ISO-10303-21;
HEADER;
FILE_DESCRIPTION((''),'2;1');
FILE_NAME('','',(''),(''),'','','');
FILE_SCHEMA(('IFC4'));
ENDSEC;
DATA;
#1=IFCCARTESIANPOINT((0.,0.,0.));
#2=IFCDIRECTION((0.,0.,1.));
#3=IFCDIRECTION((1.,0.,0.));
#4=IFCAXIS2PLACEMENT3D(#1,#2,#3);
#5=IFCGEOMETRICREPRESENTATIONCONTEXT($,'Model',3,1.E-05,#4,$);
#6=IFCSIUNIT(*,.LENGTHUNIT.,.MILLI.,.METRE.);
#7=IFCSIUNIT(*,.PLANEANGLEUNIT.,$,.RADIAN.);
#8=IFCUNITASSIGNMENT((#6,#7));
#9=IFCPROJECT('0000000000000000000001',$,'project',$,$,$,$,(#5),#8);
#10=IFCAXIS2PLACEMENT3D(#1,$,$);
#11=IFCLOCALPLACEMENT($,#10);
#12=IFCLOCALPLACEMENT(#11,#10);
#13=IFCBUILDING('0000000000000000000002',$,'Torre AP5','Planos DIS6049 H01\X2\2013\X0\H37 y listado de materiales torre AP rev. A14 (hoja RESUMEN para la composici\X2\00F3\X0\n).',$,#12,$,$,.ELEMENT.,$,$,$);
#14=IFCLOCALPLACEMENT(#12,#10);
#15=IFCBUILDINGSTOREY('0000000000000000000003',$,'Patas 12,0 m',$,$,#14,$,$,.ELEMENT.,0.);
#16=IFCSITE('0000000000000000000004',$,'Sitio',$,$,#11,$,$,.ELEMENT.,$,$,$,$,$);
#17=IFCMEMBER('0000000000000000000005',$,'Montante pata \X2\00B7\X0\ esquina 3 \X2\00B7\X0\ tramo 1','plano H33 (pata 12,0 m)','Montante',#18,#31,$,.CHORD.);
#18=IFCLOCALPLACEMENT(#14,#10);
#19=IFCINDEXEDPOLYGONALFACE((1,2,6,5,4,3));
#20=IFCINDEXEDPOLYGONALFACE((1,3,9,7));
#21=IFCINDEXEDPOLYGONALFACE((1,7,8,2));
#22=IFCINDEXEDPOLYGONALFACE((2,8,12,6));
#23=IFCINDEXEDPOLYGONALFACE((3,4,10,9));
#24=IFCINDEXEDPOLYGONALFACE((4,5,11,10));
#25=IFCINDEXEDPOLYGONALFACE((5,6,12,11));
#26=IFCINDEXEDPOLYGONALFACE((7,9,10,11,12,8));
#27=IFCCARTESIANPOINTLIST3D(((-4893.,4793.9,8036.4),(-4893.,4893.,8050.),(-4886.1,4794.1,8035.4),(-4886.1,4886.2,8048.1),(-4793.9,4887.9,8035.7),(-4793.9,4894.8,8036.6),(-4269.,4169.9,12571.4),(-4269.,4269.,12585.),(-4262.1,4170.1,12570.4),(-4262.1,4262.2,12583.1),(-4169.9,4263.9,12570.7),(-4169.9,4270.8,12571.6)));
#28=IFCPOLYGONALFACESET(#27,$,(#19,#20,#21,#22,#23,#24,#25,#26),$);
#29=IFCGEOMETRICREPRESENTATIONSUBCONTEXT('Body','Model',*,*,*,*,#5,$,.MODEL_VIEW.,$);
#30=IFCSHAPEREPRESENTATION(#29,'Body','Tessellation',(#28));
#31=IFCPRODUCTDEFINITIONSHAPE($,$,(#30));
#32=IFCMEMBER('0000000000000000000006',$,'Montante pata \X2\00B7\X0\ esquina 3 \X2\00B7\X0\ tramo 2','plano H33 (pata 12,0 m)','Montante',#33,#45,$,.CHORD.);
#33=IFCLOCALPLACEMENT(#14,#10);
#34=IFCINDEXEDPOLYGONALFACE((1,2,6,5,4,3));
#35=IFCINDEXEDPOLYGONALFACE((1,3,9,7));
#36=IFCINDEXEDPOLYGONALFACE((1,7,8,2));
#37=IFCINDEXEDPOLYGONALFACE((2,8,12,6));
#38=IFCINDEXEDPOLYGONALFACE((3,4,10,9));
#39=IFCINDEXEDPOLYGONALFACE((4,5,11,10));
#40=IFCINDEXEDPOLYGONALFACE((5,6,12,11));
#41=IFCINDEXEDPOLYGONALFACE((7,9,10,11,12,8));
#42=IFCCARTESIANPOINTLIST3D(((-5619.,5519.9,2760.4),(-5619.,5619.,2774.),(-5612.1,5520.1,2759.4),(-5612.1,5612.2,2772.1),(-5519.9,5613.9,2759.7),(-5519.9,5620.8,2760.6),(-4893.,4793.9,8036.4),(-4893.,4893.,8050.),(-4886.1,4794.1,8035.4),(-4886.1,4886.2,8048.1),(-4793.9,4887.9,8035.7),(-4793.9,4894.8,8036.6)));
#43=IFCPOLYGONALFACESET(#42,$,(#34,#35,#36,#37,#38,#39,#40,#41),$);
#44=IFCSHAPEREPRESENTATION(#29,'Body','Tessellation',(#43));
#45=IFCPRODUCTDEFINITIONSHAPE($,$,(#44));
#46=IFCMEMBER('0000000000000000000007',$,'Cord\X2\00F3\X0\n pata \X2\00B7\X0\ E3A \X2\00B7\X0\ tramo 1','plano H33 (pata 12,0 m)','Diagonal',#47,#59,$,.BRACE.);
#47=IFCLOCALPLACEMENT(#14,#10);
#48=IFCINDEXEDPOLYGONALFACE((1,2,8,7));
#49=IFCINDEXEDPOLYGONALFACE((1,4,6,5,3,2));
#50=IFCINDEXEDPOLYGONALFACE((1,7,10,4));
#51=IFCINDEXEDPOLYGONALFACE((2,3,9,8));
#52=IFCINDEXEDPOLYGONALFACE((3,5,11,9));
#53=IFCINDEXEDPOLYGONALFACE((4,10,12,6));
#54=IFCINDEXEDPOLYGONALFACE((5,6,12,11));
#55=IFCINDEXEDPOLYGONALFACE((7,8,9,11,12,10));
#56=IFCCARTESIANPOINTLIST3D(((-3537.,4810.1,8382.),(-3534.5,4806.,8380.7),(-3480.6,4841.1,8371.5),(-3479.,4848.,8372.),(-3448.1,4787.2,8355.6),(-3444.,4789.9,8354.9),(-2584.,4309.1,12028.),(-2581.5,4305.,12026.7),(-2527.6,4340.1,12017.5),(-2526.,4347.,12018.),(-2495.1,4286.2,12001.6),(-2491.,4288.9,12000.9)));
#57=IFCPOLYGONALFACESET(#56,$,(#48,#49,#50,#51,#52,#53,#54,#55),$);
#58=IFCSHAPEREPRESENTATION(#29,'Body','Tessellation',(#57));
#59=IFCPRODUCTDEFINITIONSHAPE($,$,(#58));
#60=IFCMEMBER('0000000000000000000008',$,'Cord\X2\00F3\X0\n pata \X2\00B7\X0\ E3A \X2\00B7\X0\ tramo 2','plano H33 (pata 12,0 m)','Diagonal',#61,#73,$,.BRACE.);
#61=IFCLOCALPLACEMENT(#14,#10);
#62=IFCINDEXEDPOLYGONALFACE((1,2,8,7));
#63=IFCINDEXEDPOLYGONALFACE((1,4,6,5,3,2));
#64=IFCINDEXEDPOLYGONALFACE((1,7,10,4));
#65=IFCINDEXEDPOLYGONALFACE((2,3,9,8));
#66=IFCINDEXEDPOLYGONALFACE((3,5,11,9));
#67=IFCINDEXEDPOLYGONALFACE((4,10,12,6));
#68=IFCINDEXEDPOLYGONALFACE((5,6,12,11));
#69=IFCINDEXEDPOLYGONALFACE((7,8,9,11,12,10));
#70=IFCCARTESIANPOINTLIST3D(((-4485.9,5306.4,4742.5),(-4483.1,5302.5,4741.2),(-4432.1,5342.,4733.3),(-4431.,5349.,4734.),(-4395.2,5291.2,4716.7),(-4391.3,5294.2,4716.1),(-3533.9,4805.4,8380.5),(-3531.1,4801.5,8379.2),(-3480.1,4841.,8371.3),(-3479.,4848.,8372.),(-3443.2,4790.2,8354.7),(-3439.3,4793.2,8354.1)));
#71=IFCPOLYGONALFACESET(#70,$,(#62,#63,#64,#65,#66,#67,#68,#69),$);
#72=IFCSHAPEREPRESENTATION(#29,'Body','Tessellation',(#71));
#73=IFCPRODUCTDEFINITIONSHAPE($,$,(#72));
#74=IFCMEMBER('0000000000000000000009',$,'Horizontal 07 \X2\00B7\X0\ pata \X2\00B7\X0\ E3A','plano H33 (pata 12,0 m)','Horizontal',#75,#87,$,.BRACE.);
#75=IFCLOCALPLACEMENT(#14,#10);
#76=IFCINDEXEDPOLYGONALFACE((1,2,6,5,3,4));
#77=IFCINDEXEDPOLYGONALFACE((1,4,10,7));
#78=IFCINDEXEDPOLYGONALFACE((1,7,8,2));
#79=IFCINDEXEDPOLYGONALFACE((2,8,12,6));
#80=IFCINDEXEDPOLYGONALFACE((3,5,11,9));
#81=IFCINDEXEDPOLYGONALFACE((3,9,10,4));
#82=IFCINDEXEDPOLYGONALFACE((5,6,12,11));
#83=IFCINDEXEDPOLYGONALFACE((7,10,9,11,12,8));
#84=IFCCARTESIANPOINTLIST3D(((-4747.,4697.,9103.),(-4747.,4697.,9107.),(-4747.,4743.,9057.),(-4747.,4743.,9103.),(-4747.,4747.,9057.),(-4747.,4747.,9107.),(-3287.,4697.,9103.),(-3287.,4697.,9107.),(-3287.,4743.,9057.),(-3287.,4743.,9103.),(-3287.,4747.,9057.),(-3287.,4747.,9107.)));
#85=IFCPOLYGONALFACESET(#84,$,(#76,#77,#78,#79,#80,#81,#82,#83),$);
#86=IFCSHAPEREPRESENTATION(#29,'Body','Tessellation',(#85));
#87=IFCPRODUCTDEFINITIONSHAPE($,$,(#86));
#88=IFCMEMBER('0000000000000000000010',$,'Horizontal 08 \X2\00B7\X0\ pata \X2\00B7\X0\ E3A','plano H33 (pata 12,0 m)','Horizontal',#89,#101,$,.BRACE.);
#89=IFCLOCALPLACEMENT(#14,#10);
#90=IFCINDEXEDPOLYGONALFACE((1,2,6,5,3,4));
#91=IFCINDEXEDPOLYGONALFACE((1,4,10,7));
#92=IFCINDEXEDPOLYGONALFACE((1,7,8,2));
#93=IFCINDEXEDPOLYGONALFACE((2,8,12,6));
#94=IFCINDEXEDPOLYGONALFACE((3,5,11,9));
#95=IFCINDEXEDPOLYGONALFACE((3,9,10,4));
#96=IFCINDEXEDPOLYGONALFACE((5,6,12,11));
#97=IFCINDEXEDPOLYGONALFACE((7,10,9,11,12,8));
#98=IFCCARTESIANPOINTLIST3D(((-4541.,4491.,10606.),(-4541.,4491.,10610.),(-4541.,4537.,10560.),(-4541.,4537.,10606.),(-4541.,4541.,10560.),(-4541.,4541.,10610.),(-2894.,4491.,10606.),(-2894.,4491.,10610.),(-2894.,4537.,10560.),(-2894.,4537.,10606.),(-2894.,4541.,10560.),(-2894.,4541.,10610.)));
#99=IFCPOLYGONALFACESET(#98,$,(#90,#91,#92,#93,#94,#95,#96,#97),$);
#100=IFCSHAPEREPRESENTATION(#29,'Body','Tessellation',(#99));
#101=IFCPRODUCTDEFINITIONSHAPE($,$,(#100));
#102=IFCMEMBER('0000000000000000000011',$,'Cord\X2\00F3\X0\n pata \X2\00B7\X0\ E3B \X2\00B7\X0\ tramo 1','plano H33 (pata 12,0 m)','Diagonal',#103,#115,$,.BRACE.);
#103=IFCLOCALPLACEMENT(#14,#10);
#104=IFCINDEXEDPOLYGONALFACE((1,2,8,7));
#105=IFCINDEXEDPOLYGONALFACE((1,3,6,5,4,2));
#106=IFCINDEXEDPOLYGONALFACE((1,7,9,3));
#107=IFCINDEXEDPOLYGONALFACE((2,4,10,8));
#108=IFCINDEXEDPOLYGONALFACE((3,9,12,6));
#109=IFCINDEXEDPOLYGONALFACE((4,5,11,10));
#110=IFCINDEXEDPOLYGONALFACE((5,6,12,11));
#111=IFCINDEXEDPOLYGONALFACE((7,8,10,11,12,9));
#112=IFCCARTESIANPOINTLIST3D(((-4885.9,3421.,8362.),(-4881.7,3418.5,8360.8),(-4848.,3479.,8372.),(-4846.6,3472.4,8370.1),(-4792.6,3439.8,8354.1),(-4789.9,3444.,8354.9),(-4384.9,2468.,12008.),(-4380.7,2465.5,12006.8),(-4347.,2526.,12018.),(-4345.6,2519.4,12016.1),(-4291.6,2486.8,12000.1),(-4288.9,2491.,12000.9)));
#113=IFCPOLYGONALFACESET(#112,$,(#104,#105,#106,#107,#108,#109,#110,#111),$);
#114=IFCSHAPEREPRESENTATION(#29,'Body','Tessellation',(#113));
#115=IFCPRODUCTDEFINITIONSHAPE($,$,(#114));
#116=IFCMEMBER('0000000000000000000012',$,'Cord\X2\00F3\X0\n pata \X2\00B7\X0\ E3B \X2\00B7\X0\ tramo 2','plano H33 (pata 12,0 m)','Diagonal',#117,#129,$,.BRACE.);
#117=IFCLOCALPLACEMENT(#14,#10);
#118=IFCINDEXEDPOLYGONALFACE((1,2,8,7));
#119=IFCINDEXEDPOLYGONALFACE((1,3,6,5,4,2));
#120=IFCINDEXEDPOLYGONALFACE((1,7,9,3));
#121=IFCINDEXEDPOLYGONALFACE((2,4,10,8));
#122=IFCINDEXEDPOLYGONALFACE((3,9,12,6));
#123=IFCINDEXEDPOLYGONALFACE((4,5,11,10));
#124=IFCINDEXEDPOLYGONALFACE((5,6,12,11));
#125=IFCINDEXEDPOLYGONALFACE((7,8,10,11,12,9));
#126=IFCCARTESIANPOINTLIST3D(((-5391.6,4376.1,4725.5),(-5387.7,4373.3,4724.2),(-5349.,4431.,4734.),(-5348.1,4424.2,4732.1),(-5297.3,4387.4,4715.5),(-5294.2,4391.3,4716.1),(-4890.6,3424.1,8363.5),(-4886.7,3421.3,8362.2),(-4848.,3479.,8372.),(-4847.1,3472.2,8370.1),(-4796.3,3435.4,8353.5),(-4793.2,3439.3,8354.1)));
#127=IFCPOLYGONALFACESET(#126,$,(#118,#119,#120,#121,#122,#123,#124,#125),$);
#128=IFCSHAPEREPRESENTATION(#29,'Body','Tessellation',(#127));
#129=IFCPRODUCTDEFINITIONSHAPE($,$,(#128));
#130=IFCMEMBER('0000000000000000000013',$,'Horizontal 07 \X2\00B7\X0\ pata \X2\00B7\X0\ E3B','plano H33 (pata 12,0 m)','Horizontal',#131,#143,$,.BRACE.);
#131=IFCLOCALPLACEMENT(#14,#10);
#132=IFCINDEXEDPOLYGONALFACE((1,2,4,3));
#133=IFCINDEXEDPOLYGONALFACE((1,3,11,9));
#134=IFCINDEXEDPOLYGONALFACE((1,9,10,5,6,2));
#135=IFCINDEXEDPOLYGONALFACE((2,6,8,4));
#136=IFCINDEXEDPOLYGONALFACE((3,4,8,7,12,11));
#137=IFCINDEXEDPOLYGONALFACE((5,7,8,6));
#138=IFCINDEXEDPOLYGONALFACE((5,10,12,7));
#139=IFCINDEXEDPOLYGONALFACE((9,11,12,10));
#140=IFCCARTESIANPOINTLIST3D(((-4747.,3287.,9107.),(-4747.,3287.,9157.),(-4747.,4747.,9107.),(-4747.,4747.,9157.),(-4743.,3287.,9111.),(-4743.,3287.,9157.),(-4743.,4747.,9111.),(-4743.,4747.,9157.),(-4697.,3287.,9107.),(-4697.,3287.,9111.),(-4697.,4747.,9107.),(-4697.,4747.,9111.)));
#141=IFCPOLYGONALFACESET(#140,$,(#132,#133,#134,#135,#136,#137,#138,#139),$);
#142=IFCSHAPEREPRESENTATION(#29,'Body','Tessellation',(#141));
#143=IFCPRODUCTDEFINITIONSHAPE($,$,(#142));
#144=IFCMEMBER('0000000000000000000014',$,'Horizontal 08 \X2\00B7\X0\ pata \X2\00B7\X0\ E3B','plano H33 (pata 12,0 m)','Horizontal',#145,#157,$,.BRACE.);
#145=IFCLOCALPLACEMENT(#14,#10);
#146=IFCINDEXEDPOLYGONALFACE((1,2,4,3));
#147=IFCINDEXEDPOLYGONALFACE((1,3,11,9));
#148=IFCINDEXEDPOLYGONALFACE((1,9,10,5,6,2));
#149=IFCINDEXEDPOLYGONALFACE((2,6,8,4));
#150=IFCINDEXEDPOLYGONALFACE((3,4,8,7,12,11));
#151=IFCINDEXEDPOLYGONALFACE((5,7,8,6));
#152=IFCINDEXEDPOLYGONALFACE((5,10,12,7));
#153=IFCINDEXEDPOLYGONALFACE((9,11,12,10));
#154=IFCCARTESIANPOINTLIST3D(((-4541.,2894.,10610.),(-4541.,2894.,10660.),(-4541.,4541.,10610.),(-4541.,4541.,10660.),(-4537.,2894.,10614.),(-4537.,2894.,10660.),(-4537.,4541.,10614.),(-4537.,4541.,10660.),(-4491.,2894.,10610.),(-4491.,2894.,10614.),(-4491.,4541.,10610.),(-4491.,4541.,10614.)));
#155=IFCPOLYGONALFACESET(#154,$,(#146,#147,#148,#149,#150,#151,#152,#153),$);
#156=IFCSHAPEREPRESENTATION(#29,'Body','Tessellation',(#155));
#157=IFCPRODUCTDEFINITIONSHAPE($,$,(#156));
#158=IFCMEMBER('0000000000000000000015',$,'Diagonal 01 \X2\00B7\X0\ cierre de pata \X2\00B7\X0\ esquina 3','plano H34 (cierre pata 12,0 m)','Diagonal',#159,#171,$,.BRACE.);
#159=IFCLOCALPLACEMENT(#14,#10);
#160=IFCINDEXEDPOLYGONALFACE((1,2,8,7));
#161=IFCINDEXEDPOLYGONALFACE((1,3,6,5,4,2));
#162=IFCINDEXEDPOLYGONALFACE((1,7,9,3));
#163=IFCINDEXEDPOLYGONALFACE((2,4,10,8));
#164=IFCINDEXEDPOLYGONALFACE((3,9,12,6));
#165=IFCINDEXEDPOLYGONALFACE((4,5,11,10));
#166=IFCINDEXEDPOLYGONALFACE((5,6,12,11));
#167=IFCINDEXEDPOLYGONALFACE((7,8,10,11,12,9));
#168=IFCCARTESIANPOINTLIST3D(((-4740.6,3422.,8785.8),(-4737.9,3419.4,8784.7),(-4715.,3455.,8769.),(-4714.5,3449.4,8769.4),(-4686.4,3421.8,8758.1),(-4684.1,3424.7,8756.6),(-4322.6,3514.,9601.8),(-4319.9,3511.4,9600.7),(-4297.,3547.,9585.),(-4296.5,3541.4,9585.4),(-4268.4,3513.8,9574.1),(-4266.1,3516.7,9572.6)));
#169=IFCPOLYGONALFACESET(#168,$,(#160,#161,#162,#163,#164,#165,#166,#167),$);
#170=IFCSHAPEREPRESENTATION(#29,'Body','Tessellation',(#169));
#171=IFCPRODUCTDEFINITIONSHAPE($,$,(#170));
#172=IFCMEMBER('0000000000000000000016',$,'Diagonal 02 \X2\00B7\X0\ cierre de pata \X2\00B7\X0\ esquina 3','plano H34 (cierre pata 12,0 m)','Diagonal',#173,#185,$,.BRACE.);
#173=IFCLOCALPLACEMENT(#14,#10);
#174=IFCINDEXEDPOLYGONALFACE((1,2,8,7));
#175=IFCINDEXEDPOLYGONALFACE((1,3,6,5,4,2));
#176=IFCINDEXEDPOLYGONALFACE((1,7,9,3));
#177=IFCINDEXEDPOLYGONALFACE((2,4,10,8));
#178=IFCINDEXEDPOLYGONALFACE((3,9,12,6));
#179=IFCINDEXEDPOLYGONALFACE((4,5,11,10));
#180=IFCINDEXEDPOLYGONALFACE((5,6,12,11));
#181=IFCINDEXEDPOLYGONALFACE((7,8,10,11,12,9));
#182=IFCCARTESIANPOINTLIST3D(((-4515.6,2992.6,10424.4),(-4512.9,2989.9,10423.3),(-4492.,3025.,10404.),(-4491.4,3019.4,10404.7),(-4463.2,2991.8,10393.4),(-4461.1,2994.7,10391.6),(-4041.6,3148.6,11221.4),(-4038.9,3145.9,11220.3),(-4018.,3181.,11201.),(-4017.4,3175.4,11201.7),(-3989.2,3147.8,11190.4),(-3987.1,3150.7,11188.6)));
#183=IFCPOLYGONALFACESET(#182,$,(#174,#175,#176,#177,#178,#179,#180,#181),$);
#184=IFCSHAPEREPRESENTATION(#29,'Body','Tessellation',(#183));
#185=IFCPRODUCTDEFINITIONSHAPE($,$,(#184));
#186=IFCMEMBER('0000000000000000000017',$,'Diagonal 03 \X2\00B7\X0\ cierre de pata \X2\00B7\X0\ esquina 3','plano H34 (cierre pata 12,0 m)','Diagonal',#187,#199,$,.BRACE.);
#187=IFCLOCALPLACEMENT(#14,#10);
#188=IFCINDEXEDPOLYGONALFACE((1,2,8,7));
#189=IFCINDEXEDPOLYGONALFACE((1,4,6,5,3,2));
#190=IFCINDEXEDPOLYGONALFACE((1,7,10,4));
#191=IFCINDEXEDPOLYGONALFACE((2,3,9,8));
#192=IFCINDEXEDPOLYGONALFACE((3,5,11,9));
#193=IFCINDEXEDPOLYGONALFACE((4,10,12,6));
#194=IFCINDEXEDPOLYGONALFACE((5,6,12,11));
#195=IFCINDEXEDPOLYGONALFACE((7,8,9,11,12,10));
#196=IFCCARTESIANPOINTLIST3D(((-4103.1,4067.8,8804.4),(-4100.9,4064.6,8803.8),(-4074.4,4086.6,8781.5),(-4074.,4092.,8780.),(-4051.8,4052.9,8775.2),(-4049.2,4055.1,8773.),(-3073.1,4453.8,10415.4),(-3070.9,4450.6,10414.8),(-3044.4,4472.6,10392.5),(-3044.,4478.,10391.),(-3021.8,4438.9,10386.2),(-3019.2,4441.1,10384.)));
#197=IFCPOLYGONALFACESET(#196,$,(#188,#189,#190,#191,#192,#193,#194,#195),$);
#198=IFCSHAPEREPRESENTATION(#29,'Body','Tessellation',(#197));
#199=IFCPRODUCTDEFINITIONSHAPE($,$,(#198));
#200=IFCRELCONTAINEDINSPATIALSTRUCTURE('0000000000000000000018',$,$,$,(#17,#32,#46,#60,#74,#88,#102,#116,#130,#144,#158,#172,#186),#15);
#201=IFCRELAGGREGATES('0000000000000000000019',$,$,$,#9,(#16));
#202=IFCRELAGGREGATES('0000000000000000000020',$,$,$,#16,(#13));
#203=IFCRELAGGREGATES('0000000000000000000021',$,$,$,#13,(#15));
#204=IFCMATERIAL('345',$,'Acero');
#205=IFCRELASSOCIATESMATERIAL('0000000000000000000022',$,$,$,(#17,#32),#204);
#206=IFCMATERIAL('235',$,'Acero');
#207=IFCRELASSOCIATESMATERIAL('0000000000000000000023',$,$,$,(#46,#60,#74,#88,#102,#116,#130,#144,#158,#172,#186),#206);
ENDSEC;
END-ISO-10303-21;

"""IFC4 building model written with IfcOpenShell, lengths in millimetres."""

from ifc_helpers import new_model, si_unit, frame, frame_2d, origin, origin_with_axes, place, context, subcontext, project, spatial, l_section, extrude, material, element, save


model = new_model("IFC4")

# Units and contexts
model_context = context("Model", 3, precision=1e-05, world=origin_with_axes())
body_context = subcontext(model_context, "Body", "Model", "MODEL_VIEW")
ifc_project = project(units=[si_unit("LENGTHUNIT", "METRE", prefix="MILLI"), si_unit("PLANEANGLEUNIT", "RADIAN")], contexts=[model_context])

# Site, building, storey
site_placement = place(None, origin())
site = spatial("IfcSite", under=ifc_project, at=site_placement, Name="Sitio", CompositionType="ELEMENT")
building_placement = place(site_placement, origin())
building = spatial("IfcBuilding", under=site, at=building_placement, Name="Torre AP5", Description="Planos DIS6049 H01–H37 y listado de materiales torre AP rev. A14 (hoja RESUMEN para la composición).", CompositionType="ELEMENT")
storey_placement = place(building_placement, origin())
storey = spatial("IfcBuildingStorey", under=building, at=storey_placement, Name="Patas 12,0 m", CompositionType="ELEMENT", Elevation=0.0)

# Members
ifc_material_1 = material(Name="345", Category="Acero")
member_1_placement = place(storey_placement, frame((-4269.0, 4269.0, 12585.0), z_axis=(-0.135063, 0.135063, -0.981588), x_axis=(0.990837, 0.018411, -0.133802)))
element("IfcMember", 1, at=member_1_placement, inside=storey, material=ifc_material_1, Name="Montante pata · esquina 3 · tramo 1", Description="plano H33 (pata 12,0 m)", ObjectType="Montante", PredefinedType="CHORD", context=body_context, shape_type="SweptSolid", body=[
    extrude(l_section(Depth=100.0, Width=100.0, Thickness=7.0, at=frame_2d((50.0, 50.0))), None, (0.0, 0.0, 1.0), 4620.1),
])
member_2_placement = place(storey_placement, frame((-4893.0, 4893.0, 8050.0), z_axis=(-0.13507, 0.13507, -0.981586), x_axis=(0.990836, 0.018413, -0.13381)))
element("IfcMember", 2, at=member_2_placement, inside=storey, material=ifc_material_1, Name="Montante pata · esquina 3 · tramo 2", Description="plano H33 (pata 12,0 m)", ObjectType="Montante", PredefinedType="CHORD", context=body_context, shape_type="SweptSolid", body=[
    extrude(l_section(Depth=100.0, Width=100.0, Thickness=7.0, at=frame_2d((50.0, 50.0))), None, (0.0, 0.0, 1.0), 5375.0),
])
ifc_material_2 = material(Name="235", Category="Acero")
member_3_placement = place(storey_placement, frame((-2526.0, 4347.0, 12018.0), z_axis=(-0.250681, 0.131785, -0.959058), x_axis=(0.500329, -0.83048, -0.244894)))
element("IfcMember", 3, at=member_3_placement, inside=storey, material=ifc_material_2, Name="Cordón pata · E3A · tramo 1", Description="plano H33 (pata 12,0 m)", ObjectType="Diagonal", PredefinedType="BRACE", context=body_context, shape_type="SweptSolid", body=[
    extrude(l_section(Depth=70.0, Width=70.0, Thickness=5.0, at=frame_2d((35.0, 35.0))), None, (0.0, 0.0, 1.0), 3801.6),
])
member_4_placement = place(storey_placement, frame((-3479.0, 4848.0, 8372.0), z_axis=(-0.250941, 0.13206, -0.958952), x_axis=(0.567377, -0.782575, -0.256243)))
element("IfcMember", 4, at=member_4_placement, inside=storey, material=ifc_material_2, Name="Cordón pata · E3A · tramo 2", Description="plano H33 (pata 12,0 m)", ObjectType="Diagonal", PredefinedType="BRACE", context=body_context, shape_type="SweptSolid", body=[
    extrude(l_section(Depth=70.0, Width=70.0, Thickness=5.0, at=frame_2d((35.0, 35.0))), None, (0.0, 0.0, 1.0), 3793.7),
])
member_5_placement = place(storey_placement, frame((-4747.0, 4747.0, 9107.0), z_axis=(1.0, 0.0, 0.0), x_axis=(0.0, -1.0, 0.0)))
element("IfcMember", 5, at=member_5_placement, inside=storey, material=ifc_material_2, Name="Horizontal 07 · pata · E3A", Description="plano H33 (pata 12,0 m)", ObjectType="Horizontal", PredefinedType="BRACE", context=body_context, shape_type="SweptSolid", body=[
    extrude(l_section(Depth=50.0, Width=50.0, Thickness=4.0, at=frame_2d((25.0, 25.0))), None, (0.0, 0.0, 1.0), 1460.0),
])
member_6_placement = place(storey_placement, frame((-4541.0, 4541.0, 10610.0), z_axis=(1.0, 0.0, 0.0), x_axis=(0.0, -1.0, 0.0)))
element("IfcMember", 6, at=member_6_placement, inside=storey, material=ifc_material_2, Name="Horizontal 08 · pata · E3A", Description="plano H33 (pata 12,0 m)", ObjectType="Horizontal", PredefinedType="BRACE", context=body_context, shape_type="SweptSolid", body=[
    extrude(l_section(Depth=50.0, Width=50.0, Thickness=4.0, at=frame_2d((25.0, 25.0))), None, (0.0, 0.0, 1.0), 1647.0),
])
member_7_placement = place(storey_placement, frame((-4347.0, 2526.0, 12018.0), z_axis=(-0.131785, 0.250681, -0.959058), x_axis=(0.83048, -0.500329, -0.244894)))
element("IfcMember", 7, at=member_7_placement, inside=storey, material=ifc_material_2, Name="Cordón pata · E3B · tramo 1", Description="plano H33 (pata 12,0 m)", ObjectType="Diagonal", PredefinedType="BRACE", context=body_context, shape_type="SweptSolid", body=[
    extrude(l_section(Depth=70.0, Width=70.0, Thickness=5.0, at=frame_2d((35.0, 35.0))), None, (0.0, 0.0, 1.0), 3801.6),
])
member_8_placement = place(storey_placement, frame((-4848.0, 3479.0, 8372.0), z_axis=(-0.13206, 0.250941, -0.958952), x_axis=(0.782575, -0.567377, -0.256243)))
element("IfcMember", 8, at=member_8_placement, inside=storey, material=ifc_material_2, Name="Cordón pata · E3B · tramo 2", Description="plano H33 (pata 12,0 m)", ObjectType="Diagonal", PredefinedType="BRACE", context=body_context, shape_type="SweptSolid", body=[
    extrude(l_section(Depth=70.0, Width=70.0, Thickness=5.0, at=frame_2d((35.0, 35.0))), None, (0.0, 0.0, 1.0), 3793.7),
])
member_9_placement = place(storey_placement, frame((-4747.0, 4747.0, 9107.0), z_axis=(0.0, -1.0, 0.0), x_axis=(1.0, 0.0, 0.0)))
element("IfcMember", 9, at=member_9_placement, inside=storey, material=ifc_material_2, Name="Horizontal 07 · pata · E3B", Description="plano H33 (pata 12,0 m)", ObjectType="Horizontal", PredefinedType="BRACE", context=body_context, shape_type="SweptSolid", body=[
    extrude(l_section(Depth=50.0, Width=50.0, Thickness=4.0, at=frame_2d((25.0, 25.0))), None, (0.0, 0.0, 1.0), 1460.0),
])
member_10_placement = place(storey_placement, frame((-4541.0, 4541.0, 10610.0), z_axis=(0.0, -1.0, 0.0), x_axis=(1.0, 0.0, 0.0)))
element("IfcMember", 10, at=member_10_placement, inside=storey, material=ifc_material_2, Name="Horizontal 08 · pata · E3B", Description="plano H33 (pata 12,0 m)", ObjectType="Horizontal", PredefinedType="BRACE", context=body_context, shape_type="SweptSolid", body=[
    extrude(l_section(Depth=50.0, Width=50.0, Thickness=4.0, at=frame_2d((25.0, 25.0))), None, (0.0, 0.0, 1.0), 1647.0),
])
member_11_placement = place(storey_placement, frame((-4297.0, 3547.0, 9585.0), z_axis=(-0.45364, -0.099844, -0.885574), x_axis=(0.68589, -0.673576, -0.275408)))
element("IfcMember", 11, at=member_11_placement, inside=storey, material=ifc_material_2, Name="Diagonal 01 · cierre de pata · esquina 3", Description="plano H34 (cierre pata 12,0 m)", ObjectType="Diagonal", PredefinedType="BRACE", context=body_context, shape_type="SweptSolid", body=[
    extrude(l_section(Depth=45.0, Width=45.0, Thickness=4.0, at=frame_2d((22.5, 22.5))), None, (0.0, 0.0, 1.0), 921.4),
])
member_12_placement = place(storey_placement, frame((-4018.0, 3181.0, 11201.0), z_axis=(-0.504078, -0.165899, -0.847575), x_axis=(0.685615, -0.673655, -0.275899)))
element("IfcMember", 12, at=member_12_placement, inside=storey, material=ifc_material_2, Name="Diagonal 02 · cierre de pata · esquina 3", Description="plano H34 (cierre pata 12,0 m)", ObjectType="Diagonal", PredefinedType="BRACE", context=body_context, shape_type="SweptSolid", body=[
    extrude(l_section(Depth=45.0, Width=45.0, Thickness=4.0, at=frame_2d((22.5, 22.5))), None, (0.0, 0.0, 1.0), 940.3),
])
member_13_placement = place(storey_placement, frame((-3044.0, 4478.0, 10391.0), z_axis=(-0.528017, -0.197878, -0.825859), x_axis=(0.550691, -0.820079, -0.155594)))
element("IfcMember", 13, at=member_13_placement, inside=storey, material=ifc_material_2, Name="Diagonal 03 · cierre de pata · esquina 3", Description="plano H34 (cierre pata 12,0 m)", ObjectType="Diagonal", PredefinedType="BRACE", context=body_context, shape_type="SweptSolid", body=[
    extrude(l_section(Depth=45.0, Width=45.0, Thickness=4.0, at=frame_2d((22.5, 22.5))), None, (0.0, 0.0, 1.0), 1950.7),
])

save(model, "model.ifc")
